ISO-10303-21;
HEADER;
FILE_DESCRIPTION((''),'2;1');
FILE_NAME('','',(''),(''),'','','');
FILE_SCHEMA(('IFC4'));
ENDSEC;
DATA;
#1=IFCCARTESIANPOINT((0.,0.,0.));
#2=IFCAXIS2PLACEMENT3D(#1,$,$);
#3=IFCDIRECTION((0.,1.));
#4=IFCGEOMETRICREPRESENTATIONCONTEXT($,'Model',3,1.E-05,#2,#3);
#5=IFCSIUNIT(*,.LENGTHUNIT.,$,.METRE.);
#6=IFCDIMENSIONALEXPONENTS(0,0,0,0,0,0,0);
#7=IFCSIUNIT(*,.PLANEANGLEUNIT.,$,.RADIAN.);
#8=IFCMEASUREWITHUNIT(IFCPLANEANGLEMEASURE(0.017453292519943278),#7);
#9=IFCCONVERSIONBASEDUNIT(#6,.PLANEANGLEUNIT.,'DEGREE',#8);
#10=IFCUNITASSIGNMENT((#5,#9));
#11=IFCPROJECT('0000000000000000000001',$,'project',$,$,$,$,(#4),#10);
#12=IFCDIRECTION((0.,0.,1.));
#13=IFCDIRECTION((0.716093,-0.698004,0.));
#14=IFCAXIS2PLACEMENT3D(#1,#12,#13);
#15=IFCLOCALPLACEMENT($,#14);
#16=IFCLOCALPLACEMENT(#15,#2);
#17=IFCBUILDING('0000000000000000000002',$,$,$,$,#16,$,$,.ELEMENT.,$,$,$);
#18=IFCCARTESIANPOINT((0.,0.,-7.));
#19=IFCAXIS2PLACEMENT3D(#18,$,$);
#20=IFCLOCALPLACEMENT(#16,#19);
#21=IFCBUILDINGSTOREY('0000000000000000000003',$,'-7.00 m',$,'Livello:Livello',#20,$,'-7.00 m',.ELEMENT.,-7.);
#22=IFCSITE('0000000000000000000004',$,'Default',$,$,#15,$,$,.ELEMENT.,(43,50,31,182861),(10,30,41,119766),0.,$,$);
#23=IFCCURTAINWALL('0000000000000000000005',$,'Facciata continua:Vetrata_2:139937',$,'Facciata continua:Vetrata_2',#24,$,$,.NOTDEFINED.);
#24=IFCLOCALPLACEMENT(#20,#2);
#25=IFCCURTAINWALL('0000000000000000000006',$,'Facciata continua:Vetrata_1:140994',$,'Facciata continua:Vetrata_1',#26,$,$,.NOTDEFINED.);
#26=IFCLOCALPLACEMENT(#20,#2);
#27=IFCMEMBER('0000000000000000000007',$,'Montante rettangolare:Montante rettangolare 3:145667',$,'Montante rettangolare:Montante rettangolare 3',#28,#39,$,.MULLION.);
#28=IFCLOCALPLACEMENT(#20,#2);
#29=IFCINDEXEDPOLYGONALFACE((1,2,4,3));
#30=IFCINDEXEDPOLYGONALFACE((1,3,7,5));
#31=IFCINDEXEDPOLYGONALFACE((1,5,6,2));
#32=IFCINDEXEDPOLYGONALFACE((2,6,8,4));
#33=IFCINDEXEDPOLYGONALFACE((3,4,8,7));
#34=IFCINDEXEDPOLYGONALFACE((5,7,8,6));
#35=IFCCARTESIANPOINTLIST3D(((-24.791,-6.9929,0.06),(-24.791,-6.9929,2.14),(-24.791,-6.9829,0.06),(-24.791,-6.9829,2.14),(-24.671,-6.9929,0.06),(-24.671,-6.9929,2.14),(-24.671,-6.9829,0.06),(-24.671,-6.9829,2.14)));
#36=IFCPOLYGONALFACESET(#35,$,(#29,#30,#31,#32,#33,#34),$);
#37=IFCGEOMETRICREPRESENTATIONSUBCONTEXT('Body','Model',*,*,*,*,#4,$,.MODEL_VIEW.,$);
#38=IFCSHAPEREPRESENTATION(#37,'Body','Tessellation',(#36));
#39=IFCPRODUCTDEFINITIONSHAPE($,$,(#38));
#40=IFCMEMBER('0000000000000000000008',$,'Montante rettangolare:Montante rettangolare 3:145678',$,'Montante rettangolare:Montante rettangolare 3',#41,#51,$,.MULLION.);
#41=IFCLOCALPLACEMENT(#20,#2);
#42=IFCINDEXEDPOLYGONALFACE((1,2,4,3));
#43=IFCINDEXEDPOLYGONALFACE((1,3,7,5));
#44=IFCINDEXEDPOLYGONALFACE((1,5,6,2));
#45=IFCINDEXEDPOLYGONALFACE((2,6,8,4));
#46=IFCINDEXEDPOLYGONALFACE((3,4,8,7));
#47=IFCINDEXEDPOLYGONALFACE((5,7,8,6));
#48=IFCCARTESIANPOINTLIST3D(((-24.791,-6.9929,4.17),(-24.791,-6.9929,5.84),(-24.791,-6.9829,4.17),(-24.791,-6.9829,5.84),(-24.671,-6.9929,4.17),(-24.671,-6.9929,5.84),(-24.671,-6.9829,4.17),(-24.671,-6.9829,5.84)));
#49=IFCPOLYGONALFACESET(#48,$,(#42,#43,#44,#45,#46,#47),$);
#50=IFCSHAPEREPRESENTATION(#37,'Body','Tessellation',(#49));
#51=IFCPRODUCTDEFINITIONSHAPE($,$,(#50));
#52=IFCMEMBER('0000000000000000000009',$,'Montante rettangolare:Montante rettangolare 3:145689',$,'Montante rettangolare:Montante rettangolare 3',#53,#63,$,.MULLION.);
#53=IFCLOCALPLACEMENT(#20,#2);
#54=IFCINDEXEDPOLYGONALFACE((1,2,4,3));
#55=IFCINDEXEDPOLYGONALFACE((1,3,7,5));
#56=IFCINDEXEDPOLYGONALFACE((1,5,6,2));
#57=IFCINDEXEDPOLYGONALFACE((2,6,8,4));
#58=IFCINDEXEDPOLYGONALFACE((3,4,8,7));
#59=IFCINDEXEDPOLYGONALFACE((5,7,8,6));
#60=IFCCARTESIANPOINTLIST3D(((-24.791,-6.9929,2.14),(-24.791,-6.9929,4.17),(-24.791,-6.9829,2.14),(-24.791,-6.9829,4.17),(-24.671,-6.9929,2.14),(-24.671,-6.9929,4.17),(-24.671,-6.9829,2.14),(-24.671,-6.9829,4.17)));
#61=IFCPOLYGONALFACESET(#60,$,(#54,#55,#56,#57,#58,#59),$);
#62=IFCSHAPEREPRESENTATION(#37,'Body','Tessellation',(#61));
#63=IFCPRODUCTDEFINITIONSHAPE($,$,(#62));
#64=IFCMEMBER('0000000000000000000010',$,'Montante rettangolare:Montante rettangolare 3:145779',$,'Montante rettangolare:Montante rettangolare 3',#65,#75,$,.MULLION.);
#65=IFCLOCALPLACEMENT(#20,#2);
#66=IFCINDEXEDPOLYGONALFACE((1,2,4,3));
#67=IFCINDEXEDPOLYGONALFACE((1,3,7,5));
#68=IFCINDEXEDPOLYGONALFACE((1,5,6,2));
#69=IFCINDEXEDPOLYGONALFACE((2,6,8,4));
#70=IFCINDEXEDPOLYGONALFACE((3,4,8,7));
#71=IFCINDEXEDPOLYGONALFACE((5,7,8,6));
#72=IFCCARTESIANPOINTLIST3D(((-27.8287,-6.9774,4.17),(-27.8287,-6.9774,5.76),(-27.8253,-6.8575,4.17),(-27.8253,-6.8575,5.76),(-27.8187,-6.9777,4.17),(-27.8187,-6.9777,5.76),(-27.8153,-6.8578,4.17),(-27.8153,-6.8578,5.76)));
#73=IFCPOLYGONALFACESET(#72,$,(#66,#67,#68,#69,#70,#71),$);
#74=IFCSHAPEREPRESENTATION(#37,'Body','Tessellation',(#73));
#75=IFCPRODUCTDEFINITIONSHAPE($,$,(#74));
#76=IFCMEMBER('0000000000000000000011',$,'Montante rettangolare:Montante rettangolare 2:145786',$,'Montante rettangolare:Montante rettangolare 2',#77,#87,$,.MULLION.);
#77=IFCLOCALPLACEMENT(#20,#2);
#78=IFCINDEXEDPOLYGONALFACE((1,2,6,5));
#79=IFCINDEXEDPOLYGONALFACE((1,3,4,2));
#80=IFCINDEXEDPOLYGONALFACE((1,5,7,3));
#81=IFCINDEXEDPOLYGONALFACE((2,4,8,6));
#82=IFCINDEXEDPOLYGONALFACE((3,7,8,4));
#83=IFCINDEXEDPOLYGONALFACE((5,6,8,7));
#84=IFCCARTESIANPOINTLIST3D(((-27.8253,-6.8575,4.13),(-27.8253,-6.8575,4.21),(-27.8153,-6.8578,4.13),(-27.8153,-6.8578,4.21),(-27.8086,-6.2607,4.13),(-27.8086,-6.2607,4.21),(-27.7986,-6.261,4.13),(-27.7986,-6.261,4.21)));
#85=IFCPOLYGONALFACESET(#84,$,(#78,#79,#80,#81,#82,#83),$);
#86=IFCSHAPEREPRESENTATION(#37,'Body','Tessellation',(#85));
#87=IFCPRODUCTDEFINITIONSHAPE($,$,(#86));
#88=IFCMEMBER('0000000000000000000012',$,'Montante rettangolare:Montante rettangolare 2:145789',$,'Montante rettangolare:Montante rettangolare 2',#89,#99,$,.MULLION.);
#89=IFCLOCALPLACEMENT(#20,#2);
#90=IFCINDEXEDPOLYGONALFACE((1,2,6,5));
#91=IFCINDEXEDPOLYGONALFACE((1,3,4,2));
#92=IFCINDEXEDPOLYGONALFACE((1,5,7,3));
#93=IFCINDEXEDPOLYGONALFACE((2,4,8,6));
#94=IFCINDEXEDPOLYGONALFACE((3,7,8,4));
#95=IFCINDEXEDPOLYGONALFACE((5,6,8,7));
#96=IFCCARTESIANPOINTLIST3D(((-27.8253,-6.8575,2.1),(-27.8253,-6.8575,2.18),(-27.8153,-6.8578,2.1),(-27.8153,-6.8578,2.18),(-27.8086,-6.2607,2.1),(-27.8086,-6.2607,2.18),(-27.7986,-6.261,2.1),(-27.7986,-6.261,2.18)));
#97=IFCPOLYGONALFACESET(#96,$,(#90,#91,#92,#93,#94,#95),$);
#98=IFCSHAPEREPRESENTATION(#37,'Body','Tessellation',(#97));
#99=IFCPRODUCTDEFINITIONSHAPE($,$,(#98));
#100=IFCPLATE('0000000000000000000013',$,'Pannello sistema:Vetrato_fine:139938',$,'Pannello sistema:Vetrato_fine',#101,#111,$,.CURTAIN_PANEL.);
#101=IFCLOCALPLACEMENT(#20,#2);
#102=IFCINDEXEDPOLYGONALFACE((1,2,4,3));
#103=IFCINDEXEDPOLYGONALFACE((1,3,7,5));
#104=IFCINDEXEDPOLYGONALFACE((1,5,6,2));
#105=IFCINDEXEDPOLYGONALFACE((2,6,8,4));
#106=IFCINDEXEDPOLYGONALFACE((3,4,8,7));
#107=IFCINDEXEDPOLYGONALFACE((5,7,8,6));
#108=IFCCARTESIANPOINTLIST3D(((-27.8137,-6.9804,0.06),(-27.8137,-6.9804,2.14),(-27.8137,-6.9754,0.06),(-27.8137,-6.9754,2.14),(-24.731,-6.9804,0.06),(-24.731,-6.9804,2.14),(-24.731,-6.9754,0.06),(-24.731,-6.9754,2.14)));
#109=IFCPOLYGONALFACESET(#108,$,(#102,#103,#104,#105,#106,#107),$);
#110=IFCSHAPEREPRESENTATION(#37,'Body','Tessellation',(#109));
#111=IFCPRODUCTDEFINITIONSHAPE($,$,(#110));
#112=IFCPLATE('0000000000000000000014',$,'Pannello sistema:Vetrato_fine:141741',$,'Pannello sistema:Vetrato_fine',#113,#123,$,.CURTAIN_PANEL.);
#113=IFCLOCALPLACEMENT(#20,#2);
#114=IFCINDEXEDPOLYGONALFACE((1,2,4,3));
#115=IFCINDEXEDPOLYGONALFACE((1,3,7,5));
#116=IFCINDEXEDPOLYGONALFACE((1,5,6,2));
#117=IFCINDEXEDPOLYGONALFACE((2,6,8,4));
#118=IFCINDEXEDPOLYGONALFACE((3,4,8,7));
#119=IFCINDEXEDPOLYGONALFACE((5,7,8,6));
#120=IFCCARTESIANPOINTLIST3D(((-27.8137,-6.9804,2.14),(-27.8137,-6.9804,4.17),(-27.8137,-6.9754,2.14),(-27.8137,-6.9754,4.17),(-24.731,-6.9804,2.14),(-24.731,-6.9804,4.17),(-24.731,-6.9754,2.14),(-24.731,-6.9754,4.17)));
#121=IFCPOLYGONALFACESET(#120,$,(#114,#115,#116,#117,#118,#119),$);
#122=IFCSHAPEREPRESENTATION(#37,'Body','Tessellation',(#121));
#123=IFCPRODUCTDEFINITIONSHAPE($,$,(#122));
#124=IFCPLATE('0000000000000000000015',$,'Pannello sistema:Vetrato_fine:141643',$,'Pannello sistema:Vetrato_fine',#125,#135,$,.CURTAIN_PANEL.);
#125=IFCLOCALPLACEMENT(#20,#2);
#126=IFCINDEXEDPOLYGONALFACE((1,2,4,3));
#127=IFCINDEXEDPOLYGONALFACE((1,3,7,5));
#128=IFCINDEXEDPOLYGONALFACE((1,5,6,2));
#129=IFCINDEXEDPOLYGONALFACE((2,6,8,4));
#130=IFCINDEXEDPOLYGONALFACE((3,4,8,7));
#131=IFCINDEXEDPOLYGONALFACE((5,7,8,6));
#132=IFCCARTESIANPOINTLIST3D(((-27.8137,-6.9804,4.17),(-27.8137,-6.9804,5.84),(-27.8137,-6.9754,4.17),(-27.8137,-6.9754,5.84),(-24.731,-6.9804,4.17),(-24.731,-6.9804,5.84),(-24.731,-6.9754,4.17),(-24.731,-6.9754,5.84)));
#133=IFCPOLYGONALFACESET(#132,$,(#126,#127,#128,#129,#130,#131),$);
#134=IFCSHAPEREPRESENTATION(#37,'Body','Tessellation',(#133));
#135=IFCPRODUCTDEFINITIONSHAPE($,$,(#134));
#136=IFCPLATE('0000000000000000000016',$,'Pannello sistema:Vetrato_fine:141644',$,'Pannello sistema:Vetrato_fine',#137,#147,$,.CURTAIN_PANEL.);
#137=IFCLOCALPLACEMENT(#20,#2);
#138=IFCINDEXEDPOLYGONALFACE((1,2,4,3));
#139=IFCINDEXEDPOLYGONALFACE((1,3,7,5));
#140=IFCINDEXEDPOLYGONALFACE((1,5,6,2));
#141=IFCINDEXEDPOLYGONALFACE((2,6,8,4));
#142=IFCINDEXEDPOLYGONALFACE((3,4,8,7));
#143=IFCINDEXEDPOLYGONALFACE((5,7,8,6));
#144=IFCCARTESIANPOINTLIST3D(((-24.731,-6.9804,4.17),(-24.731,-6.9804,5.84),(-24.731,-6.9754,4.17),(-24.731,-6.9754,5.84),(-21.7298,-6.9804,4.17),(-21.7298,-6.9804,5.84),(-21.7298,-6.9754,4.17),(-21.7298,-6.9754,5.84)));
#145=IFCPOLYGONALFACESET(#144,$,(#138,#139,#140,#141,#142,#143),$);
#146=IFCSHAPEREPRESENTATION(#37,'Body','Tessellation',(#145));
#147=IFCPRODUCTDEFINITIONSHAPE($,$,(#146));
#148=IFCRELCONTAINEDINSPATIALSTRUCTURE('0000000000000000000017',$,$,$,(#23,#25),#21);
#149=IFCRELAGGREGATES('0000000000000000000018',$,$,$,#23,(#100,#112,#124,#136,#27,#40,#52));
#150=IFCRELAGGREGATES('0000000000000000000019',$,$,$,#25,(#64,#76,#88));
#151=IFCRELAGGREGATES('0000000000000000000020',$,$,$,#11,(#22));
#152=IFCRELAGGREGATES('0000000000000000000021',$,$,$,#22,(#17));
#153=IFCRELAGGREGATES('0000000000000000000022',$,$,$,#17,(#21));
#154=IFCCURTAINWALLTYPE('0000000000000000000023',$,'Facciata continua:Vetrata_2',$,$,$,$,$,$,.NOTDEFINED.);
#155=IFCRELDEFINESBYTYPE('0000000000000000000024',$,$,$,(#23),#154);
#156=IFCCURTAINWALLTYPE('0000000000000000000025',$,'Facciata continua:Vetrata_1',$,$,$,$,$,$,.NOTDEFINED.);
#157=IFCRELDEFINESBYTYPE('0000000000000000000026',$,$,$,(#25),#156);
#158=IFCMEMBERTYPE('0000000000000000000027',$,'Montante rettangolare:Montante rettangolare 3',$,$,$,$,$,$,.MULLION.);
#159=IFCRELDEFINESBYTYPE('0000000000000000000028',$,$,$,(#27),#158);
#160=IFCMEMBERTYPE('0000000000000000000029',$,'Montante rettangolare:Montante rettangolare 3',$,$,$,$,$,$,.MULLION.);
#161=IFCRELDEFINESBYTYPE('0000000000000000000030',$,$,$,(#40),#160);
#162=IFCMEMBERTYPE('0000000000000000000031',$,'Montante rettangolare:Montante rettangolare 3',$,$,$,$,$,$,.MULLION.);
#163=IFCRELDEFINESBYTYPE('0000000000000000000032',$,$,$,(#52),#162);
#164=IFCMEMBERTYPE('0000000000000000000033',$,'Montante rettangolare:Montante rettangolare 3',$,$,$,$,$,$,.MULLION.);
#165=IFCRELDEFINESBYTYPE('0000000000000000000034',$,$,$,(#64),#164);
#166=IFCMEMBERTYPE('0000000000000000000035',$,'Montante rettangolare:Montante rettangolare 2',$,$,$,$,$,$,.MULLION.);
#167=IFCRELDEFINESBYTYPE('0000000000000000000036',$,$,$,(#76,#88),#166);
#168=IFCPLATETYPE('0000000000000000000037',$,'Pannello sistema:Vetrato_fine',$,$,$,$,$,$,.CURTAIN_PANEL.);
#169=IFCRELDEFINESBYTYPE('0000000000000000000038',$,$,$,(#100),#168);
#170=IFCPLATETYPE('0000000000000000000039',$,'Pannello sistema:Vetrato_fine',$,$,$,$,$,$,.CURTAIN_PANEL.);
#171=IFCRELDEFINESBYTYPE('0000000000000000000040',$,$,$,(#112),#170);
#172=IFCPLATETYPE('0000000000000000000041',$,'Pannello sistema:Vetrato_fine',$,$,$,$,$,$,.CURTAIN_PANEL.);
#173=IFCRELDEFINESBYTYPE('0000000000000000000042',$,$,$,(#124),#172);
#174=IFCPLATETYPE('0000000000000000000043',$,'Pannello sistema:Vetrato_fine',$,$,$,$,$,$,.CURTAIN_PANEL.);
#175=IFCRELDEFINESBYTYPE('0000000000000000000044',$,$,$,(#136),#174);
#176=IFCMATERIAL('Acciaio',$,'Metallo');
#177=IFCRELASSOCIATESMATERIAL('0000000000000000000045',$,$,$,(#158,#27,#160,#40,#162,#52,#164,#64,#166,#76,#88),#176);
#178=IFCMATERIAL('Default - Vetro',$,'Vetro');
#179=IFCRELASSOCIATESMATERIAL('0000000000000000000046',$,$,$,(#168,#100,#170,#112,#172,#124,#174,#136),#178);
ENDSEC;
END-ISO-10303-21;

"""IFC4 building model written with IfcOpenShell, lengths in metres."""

from ifc_helpers import new_model, entity, si_unit, converted_unit, direction, frame, origin, place, context, subcontext, project, spatial, indexed_curve, outline, extrude, source, transform, mapped, material, type_object, type_shapes, element, aggregate, save


model = new_model("IFC4")

# Units and contexts
model_context = context("Model", 3, precision=1e-05, world=origin(), true_north=direction((0.0, 1.0)))
body_context = subcontext(model_context, "Body", "Model", "MODEL_VIEW")
ifc_project = project(units=[si_unit("LENGTHUNIT", "METRE"), converted_unit("PLANEANGLEUNIT", "DEGREE", entity("IfcPlaneAngleMeasure", 0.017453292519943278), si_unit("PLANEANGLEUNIT", "RADIAN"), dimensions=[0, 0, 0, 0, 0, 0, 0])], contexts=[model_context])

# Site, building, storey
site_placement = place(None, frame((0.0, 0.0, 0.0), z_axis=(0.0, 0.0, 1.0), x_axis=(0.716093, -0.698004, 0.0)))
site = spatial("IfcSite", under=ifc_project, at=site_placement, Name="Default", CompositionType="ELEMENT", RefLatitude=(43, 50, 31, 182861), RefLongitude=(10, 30, 41, 119766), RefElevation=0.0)
building_placement = place(site_placement, origin())
building = spatial("IfcBuilding", under=site, at=building_placement, CompositionType="ELEMENT")
storey_placement = place(building_placement, frame((0.0, 0.0, -7.0)))
storey = spatial("IfcBuildingStorey", under=building, at=storey_placement, Name="-7.00 m", ObjectType="Livello:Livello", LongName="-7.00 m", CompositionType="ELEMENT", Elevation=-7.0)

# Curtain walls
curtain_wall_type_1 = type_object("IfcCurtainWallType", Name="Facciata continua:Vetrata_2", PredefinedType="NOTDEFINED")
curtain_wall_1_placement = place(storey_placement, frame((0.0, 0.0, 7.0)))
curtain_wall_1 = element("IfcCurtainWall", 1, at=curtain_wall_1_placement, inside=storey, type_object=curtain_wall_type_1, Name="Facciata continua:Vetrata_2:139937", ObjectType="Facciata continua:Vetrata_2", PredefinedType="NOTDEFINED")
ifc_material_1 = material(Name="Acciaio", Category="Metallo")
curtain_wall_type_2 = type_object("IfcCurtainWallType", Name="Facciata continua:Vetrata_1", PredefinedType="NOTDEFINED")
curtain_wall_2_placement = place(storey_placement, frame((0.0, 0.0, 7.0)))
curtain_wall_2 = element("IfcCurtainWall", 2, at=curtain_wall_2_placement, inside=storey, type_object=curtain_wall_type_2, Name="Facciata continua:Vetrata_1:140994", ObjectType="Facciata continua:Vetrata_1", PredefinedType="NOTDEFINED")

# Members
member_type_1 = type_object("IfcMemberType", Name="Montante rettangolare:Montante rettangolare 3", PredefinedType="MULLION", material=ifc_material_1)
shared_shape_1 = source(origin(), body_context, "Body", "SweptSolid", [
    extrude(outline(indexed_curve([(-0.06, -0.005), (0.06, -0.005), (0.06, 0.005), (-0.06, 0.005), (-0.06, -0.005)], self_intersect=False)), frame((0.0, 0.01, -2.08), z_axis=(0.0, 0.0, 1.0), x_axis=(-1.0, 0.0, 0.0)), (0.0, 0.0, 1.0), 2.08),
])
type_shapes(member_type_1, [shared_shape_1])
member_1_placement = place(curtain_wall_1_placement, frame((-24.731, -6.9779, -6.94), z_axis=(0.0, 0.0, -1.0), x_axis=(1.0, 0.0, 0.0)))
member_1 = element("IfcMember", 3, at=member_1_placement, type_object=member_type_1, material=ifc_material_1, Name="Montante rettangolare:Montante rettangolare 3:145667", ObjectType="Montante rettangolare:Montante rettangolare 3", PredefinedType="MULLION", context=body_context, shape_type="MappedRepresentation", body=[
    mapped(shared_shape_1, transform((0.0, 0.0, 0.0), scale=1.0)),
])
member_type_2 = type_object("IfcMemberType", Name="Montante rettangolare:Montante rettangolare 3", PredefinedType="MULLION", material=ifc_material_1)
shared_shape_2 = source(origin(), body_context, "Body", "SweptSolid", [
    extrude(outline(indexed_curve([(-0.06, -0.005), (0.06, -0.005), (0.06, 0.005), (-0.06, 0.005), (-0.06, -0.005)], self_intersect=False)), frame((0.0, 0.01, -1.67), z_axis=(0.0, 0.0, 1.0), x_axis=(-1.0, 0.0, 0.0)), (0.0, 0.0, 1.0), 1.67),
])
type_shapes(member_type_2, [shared_shape_2])
member_2_placement = place(curtain_wall_1_placement, frame((-24.731, -6.9779, -2.83), z_axis=(0.0, 0.0, -1.0), x_axis=(1.0, 0.0, 0.0)))
member_2 = element("IfcMember", 4, at=member_2_placement, type_object=member_type_2, material=ifc_material_1, Name="Montante rettangolare:Montante rettangolare 3:145678", ObjectType="Montante rettangolare:Montante rettangolare 3", PredefinedType="MULLION", context=body_context, shape_type="MappedRepresentation", body=[
    mapped(shared_shape_2, transform((0.0, 0.0, 0.0), scale=1.0)),
])
member_type_3 = type_object("IfcMemberType", Name="Montante rettangolare:Montante rettangolare 3", PredefinedType="MULLION", material=ifc_material_1)
shared_shape_3 = source(origin(), body_context, "Body", "SweptSolid", [
    extrude(outline(indexed_curve([(-0.06, -0.005), (0.06, -0.005), (0.06, 0.005), (-0.06, 0.005), (-0.06, -0.005)], self_intersect=False)), frame((0.0, 0.01, -2.03), z_axis=(0.0, 0.0, 1.0), x_axis=(-1.0, 0.0, 0.0)), (0.0, 0.0, 1.0), 2.03),
])
type_shapes(member_type_3, [shared_shape_3])
member_3_placement = place(curtain_wall_1_placement, frame((-24.731, -6.9779, -4.86), z_axis=(0.0, 0.0, -1.0), x_axis=(1.0, 0.0, 0.0)))
member_3 = element("IfcMember", 5, at=member_3_placement, type_object=member_type_3, material=ifc_material_1, Name="Montante rettangolare:Montante rettangolare 3:145689", ObjectType="Montante rettangolare:Montante rettangolare 3", PredefinedType="MULLION", context=body_context, shape_type="MappedRepresentation", body=[
    mapped(shared_shape_3, transform((0.0, 0.0, 0.0), scale=1.0)),
])
member_type_4 = type_object("IfcMemberType", Name="Montante rettangolare:Montante rettangolare 3", PredefinedType="MULLION", material=ifc_material_1)
shared_shape_4 = source(origin(), body_context, "Body", "SweptSolid", [
    extrude(outline(indexed_curve([(-0.06, -0.005), (0.06, -0.005), (0.06, 0.005), (-0.06, 0.005), (-0.06, -0.005)], self_intersect=False)), frame((-0.06, 0.01, -1.59), z_axis=(0.0, 0.0, 1.0), x_axis=(-1.0, 0.0, 0.0)), (0.0, 0.0, 1.0), 1.59),
])
type_shapes(member_type_4, [shared_shape_4])
member_4_placement = place(curtain_wall_2_placement, frame((-27.8137, -6.9779, -2.83), z_axis=(0.0, 0.0, -1.0), x_axis=(-0.02798, -0.999608, 0.0)))
member_4 = element("IfcMember", 6, at=member_4_placement, type_object=member_type_4, material=ifc_material_1, Name="Montante rettangolare:Montante rettangolare 3:145779", ObjectType="Montante rettangolare:Montante rettangolare 3", PredefinedType="MULLION", context=body_context, shape_type="MappedRepresentation", body=[
    mapped(shared_shape_4, transform((0.0, 0.0, 0.0), scale=1.0)),
])
member_type_5 = type_object("IfcMemberType", Name="Montante rettangolare:Montante rettangolare 2", PredefinedType="MULLION", material=ifc_material_1)
shared_shape_5 = source(origin(), body_context, "Body", "SweptSolid", [
    extrude(outline(indexed_curve([(-0.04, -0.005), (0.04, -0.005), (0.04, 0.005), (-0.04, 0.005), (-0.04, -0.005)], self_intersect=False)), frame((0.0, 0.01, -0.597), z_axis=(0.0, 0.0, 1.0), x_axis=(-1.0, 0.0, 0.0)), (0.0, 0.0, 1.0), 0.597),
])
type_shapes(member_type_5, [shared_shape_5])
member_5_placement = place(curtain_wall_2_placement, frame((-27.8103, -6.8579, -2.83), z_axis=(-0.02798, -0.999608, 0.0), x_axis=(0.0, 0.0, 1.0)))
member_5 = element("IfcMember", 7, at=member_5_placement, type_object=member_type_5, material=ifc_material_1, Name="Montante rettangolare:Montante rettangolare 2:145786", ObjectType="Montante rettangolare:Montante rettangolare 2", PredefinedType="MULLION", context=body_context, shape_type="MappedRepresentation", body=[
    mapped(shared_shape_5, transform((0.0, 0.0, 0.0), scale=1.0)),
])
member_6_placement = place(curtain_wall_2_placement, frame((-27.8103, -6.8579, -4.86), z_axis=(-0.02798, -0.999608, 0.0), x_axis=(0.0, 0.0, 1.0)))
member_6 = element("IfcMember", 8, at=member_6_placement, type_object=member_type_5, material=ifc_material_1, Name="Montante rettangolare:Montante rettangolare 2:145789", ObjectType="Montante rettangolare:Montante rettangolare 2", PredefinedType="MULLION", context=body_context, shape_type="MappedRepresentation", body=[
    mapped(shared_shape_5, transform((0.0, 0.0, 0.0), scale=1.0)),
])

# Plates
ifc_material_2 = material(Name="Default - Vetro", Category="Vetro")
plate_type_1 = type_object("IfcPlateType", Name="Pannello sistema:Vetrato_fine", PredefinedType="CURTAIN_PANEL", material=ifc_material_2)
shared_shape_6 = source(origin(), body_context, "Body", "SweptSolid", [
    extrude(outline(indexed_curve([(-0.0025, -1.5414), (0.0025, -1.5414), (0.0025, 1.5414), (-0.0025, 1.5414), (-0.0025, -1.5414)], self_intersect=False)), frame((0.0, 0.0, 0.0), z_axis=(0.0, 0.0, 1.0), x_axis=(0.0, 1.0, 0.0)), (0.0, 0.0, 1.0), 2.08),
])
type_shapes(plate_type_1, [shared_shape_6])
plate_1_placement = place(curtain_wall_1_placement, frame((-26.2723, -6.9779, -6.94)))
plate_1 = element("IfcPlate", 9, at=plate_1_placement, type_object=plate_type_1, material=ifc_material_2, Name="Pannello sistema:Vetrato_fine:139938", ObjectType="Pannello sistema:Vetrato_fine", PredefinedType="CURTAIN_PANEL", context=body_context, shape_type="MappedRepresentation", body=[
    mapped(shared_shape_6, transform((0.0, 0.0, 0.0), scale=1.0)),
])
plate_type_2 = type_object("IfcPlateType", Name="Pannello sistema:Vetrato_fine", PredefinedType="CURTAIN_PANEL", material=ifc_material_2)
shared_shape_7 = source(origin(), body_context, "Body", "SweptSolid", [
    extrude(outline(indexed_curve([(-0.0025, -1.5414), (0.0025, -1.5414), (0.0025, 1.5414), (-0.0025, 1.5414), (-0.0025, -1.5414)], self_intersect=False)), frame((0.0, 0.0, 0.0), z_axis=(0.0, 0.0, 1.0), x_axis=(0.0, 1.0, 0.0)), (0.0, 0.0, 1.0), 2.03),
])
type_shapes(plate_type_2, [shared_shape_7])
plate_2_placement = place(curtain_wall_1_placement, frame((-26.2723, -6.9779, -4.86)))
plate_2 = element("IfcPlate", 10, at=plate_2_placement, type_object=plate_type_2, material=ifc_material_2, Name="Pannello sistema:Vetrato_fine:141741", ObjectType="Pannello sistema:Vetrato_fine", PredefinedType="CURTAIN_PANEL", context=body_context, shape_type="MappedRepresentation", body=[
    mapped(shared_shape_7, transform((0.0, 0.0, 0.0), scale=1.0)),
])
plate_type_3 = type_object("IfcPlateType", Name="Pannello sistema:Vetrato_fine", PredefinedType="CURTAIN_PANEL", material=ifc_material_2)
shared_shape_8 = source(origin(), body_context, "Body", "SweptSolid", [
    extrude(outline(indexed_curve([(-0.0025, -1.5414), (0.0025, -1.5414), (0.0025, 1.5414), (-0.0025, 1.5414), (-0.0025, -1.5414)], self_intersect=False)), frame((0.0, 0.0, 0.0), z_axis=(0.0, 0.0, 1.0), x_axis=(0.0, 1.0, 0.0)), (0.0, 0.0, 1.0), 1.67),
])
type_shapes(plate_type_3, [shared_shape_8])
plate_3_placement = place(curtain_wall_1_placement, frame((-26.2723, -6.9779, -2.83)))
plate_3 = element("IfcPlate", 11, at=plate_3_placement, type_object=plate_type_3, material=ifc_material_2, Name="Pannello sistema:Vetrato_fine:141643", ObjectType="Pannello sistema:Vetrato_fine", PredefinedType="CURTAIN_PANEL", context=body_context, shape_type="MappedRepresentation", body=[
    mapped(shared_shape_8, transform((0.0, 0.0, 0.0), scale=1.0)),
])
plate_type_4 = type_object("IfcPlateType", Name="Pannello sistema:Vetrato_fine", PredefinedType="CURTAIN_PANEL", material=ifc_material_2)
shared_shape_9 = source(origin(), body_context, "Body", "SweptSolid", [
    extrude(outline(indexed_curve([(-0.0025, -1.5006), (0.0025, -1.5006), (0.0025, 1.5006), (-0.0025, 1.5006), (-0.0025, -1.5006)], self_intersect=False)), frame((0.0, 0.0, 0.0), z_axis=(0.0, 0.0, 1.0), x_axis=(0.0, 1.0, 0.0)), (0.0, 0.0, 1.0), 1.67),
])
type_shapes(plate_type_4, [shared_shape_9])
plate_4_placement = place(curtain_wall_1_placement, frame((-23.2304, -6.9779, -2.83)))
plate_4 = element("IfcPlate", 12, at=plate_4_placement, type_object=plate_type_4, material=ifc_material_2, Name="Pannello sistema:Vetrato_fine:141644", ObjectType="Pannello sistema:Vetrato_fine", PredefinedType="CURTAIN_PANEL", context=body_context, shape_type="MappedRepresentation", body=[
    mapped(shared_shape_9, transform((0.0, 0.0, 0.0), scale=1.0)),
])
aggregate(curtain_wall_1, [plate_1, plate_2, plate_3, plate_4, member_1, member_2, member_3])
aggregate(curtain_wall_2, [member_4, member_5, member_6])

save(model, "model.ifc")
